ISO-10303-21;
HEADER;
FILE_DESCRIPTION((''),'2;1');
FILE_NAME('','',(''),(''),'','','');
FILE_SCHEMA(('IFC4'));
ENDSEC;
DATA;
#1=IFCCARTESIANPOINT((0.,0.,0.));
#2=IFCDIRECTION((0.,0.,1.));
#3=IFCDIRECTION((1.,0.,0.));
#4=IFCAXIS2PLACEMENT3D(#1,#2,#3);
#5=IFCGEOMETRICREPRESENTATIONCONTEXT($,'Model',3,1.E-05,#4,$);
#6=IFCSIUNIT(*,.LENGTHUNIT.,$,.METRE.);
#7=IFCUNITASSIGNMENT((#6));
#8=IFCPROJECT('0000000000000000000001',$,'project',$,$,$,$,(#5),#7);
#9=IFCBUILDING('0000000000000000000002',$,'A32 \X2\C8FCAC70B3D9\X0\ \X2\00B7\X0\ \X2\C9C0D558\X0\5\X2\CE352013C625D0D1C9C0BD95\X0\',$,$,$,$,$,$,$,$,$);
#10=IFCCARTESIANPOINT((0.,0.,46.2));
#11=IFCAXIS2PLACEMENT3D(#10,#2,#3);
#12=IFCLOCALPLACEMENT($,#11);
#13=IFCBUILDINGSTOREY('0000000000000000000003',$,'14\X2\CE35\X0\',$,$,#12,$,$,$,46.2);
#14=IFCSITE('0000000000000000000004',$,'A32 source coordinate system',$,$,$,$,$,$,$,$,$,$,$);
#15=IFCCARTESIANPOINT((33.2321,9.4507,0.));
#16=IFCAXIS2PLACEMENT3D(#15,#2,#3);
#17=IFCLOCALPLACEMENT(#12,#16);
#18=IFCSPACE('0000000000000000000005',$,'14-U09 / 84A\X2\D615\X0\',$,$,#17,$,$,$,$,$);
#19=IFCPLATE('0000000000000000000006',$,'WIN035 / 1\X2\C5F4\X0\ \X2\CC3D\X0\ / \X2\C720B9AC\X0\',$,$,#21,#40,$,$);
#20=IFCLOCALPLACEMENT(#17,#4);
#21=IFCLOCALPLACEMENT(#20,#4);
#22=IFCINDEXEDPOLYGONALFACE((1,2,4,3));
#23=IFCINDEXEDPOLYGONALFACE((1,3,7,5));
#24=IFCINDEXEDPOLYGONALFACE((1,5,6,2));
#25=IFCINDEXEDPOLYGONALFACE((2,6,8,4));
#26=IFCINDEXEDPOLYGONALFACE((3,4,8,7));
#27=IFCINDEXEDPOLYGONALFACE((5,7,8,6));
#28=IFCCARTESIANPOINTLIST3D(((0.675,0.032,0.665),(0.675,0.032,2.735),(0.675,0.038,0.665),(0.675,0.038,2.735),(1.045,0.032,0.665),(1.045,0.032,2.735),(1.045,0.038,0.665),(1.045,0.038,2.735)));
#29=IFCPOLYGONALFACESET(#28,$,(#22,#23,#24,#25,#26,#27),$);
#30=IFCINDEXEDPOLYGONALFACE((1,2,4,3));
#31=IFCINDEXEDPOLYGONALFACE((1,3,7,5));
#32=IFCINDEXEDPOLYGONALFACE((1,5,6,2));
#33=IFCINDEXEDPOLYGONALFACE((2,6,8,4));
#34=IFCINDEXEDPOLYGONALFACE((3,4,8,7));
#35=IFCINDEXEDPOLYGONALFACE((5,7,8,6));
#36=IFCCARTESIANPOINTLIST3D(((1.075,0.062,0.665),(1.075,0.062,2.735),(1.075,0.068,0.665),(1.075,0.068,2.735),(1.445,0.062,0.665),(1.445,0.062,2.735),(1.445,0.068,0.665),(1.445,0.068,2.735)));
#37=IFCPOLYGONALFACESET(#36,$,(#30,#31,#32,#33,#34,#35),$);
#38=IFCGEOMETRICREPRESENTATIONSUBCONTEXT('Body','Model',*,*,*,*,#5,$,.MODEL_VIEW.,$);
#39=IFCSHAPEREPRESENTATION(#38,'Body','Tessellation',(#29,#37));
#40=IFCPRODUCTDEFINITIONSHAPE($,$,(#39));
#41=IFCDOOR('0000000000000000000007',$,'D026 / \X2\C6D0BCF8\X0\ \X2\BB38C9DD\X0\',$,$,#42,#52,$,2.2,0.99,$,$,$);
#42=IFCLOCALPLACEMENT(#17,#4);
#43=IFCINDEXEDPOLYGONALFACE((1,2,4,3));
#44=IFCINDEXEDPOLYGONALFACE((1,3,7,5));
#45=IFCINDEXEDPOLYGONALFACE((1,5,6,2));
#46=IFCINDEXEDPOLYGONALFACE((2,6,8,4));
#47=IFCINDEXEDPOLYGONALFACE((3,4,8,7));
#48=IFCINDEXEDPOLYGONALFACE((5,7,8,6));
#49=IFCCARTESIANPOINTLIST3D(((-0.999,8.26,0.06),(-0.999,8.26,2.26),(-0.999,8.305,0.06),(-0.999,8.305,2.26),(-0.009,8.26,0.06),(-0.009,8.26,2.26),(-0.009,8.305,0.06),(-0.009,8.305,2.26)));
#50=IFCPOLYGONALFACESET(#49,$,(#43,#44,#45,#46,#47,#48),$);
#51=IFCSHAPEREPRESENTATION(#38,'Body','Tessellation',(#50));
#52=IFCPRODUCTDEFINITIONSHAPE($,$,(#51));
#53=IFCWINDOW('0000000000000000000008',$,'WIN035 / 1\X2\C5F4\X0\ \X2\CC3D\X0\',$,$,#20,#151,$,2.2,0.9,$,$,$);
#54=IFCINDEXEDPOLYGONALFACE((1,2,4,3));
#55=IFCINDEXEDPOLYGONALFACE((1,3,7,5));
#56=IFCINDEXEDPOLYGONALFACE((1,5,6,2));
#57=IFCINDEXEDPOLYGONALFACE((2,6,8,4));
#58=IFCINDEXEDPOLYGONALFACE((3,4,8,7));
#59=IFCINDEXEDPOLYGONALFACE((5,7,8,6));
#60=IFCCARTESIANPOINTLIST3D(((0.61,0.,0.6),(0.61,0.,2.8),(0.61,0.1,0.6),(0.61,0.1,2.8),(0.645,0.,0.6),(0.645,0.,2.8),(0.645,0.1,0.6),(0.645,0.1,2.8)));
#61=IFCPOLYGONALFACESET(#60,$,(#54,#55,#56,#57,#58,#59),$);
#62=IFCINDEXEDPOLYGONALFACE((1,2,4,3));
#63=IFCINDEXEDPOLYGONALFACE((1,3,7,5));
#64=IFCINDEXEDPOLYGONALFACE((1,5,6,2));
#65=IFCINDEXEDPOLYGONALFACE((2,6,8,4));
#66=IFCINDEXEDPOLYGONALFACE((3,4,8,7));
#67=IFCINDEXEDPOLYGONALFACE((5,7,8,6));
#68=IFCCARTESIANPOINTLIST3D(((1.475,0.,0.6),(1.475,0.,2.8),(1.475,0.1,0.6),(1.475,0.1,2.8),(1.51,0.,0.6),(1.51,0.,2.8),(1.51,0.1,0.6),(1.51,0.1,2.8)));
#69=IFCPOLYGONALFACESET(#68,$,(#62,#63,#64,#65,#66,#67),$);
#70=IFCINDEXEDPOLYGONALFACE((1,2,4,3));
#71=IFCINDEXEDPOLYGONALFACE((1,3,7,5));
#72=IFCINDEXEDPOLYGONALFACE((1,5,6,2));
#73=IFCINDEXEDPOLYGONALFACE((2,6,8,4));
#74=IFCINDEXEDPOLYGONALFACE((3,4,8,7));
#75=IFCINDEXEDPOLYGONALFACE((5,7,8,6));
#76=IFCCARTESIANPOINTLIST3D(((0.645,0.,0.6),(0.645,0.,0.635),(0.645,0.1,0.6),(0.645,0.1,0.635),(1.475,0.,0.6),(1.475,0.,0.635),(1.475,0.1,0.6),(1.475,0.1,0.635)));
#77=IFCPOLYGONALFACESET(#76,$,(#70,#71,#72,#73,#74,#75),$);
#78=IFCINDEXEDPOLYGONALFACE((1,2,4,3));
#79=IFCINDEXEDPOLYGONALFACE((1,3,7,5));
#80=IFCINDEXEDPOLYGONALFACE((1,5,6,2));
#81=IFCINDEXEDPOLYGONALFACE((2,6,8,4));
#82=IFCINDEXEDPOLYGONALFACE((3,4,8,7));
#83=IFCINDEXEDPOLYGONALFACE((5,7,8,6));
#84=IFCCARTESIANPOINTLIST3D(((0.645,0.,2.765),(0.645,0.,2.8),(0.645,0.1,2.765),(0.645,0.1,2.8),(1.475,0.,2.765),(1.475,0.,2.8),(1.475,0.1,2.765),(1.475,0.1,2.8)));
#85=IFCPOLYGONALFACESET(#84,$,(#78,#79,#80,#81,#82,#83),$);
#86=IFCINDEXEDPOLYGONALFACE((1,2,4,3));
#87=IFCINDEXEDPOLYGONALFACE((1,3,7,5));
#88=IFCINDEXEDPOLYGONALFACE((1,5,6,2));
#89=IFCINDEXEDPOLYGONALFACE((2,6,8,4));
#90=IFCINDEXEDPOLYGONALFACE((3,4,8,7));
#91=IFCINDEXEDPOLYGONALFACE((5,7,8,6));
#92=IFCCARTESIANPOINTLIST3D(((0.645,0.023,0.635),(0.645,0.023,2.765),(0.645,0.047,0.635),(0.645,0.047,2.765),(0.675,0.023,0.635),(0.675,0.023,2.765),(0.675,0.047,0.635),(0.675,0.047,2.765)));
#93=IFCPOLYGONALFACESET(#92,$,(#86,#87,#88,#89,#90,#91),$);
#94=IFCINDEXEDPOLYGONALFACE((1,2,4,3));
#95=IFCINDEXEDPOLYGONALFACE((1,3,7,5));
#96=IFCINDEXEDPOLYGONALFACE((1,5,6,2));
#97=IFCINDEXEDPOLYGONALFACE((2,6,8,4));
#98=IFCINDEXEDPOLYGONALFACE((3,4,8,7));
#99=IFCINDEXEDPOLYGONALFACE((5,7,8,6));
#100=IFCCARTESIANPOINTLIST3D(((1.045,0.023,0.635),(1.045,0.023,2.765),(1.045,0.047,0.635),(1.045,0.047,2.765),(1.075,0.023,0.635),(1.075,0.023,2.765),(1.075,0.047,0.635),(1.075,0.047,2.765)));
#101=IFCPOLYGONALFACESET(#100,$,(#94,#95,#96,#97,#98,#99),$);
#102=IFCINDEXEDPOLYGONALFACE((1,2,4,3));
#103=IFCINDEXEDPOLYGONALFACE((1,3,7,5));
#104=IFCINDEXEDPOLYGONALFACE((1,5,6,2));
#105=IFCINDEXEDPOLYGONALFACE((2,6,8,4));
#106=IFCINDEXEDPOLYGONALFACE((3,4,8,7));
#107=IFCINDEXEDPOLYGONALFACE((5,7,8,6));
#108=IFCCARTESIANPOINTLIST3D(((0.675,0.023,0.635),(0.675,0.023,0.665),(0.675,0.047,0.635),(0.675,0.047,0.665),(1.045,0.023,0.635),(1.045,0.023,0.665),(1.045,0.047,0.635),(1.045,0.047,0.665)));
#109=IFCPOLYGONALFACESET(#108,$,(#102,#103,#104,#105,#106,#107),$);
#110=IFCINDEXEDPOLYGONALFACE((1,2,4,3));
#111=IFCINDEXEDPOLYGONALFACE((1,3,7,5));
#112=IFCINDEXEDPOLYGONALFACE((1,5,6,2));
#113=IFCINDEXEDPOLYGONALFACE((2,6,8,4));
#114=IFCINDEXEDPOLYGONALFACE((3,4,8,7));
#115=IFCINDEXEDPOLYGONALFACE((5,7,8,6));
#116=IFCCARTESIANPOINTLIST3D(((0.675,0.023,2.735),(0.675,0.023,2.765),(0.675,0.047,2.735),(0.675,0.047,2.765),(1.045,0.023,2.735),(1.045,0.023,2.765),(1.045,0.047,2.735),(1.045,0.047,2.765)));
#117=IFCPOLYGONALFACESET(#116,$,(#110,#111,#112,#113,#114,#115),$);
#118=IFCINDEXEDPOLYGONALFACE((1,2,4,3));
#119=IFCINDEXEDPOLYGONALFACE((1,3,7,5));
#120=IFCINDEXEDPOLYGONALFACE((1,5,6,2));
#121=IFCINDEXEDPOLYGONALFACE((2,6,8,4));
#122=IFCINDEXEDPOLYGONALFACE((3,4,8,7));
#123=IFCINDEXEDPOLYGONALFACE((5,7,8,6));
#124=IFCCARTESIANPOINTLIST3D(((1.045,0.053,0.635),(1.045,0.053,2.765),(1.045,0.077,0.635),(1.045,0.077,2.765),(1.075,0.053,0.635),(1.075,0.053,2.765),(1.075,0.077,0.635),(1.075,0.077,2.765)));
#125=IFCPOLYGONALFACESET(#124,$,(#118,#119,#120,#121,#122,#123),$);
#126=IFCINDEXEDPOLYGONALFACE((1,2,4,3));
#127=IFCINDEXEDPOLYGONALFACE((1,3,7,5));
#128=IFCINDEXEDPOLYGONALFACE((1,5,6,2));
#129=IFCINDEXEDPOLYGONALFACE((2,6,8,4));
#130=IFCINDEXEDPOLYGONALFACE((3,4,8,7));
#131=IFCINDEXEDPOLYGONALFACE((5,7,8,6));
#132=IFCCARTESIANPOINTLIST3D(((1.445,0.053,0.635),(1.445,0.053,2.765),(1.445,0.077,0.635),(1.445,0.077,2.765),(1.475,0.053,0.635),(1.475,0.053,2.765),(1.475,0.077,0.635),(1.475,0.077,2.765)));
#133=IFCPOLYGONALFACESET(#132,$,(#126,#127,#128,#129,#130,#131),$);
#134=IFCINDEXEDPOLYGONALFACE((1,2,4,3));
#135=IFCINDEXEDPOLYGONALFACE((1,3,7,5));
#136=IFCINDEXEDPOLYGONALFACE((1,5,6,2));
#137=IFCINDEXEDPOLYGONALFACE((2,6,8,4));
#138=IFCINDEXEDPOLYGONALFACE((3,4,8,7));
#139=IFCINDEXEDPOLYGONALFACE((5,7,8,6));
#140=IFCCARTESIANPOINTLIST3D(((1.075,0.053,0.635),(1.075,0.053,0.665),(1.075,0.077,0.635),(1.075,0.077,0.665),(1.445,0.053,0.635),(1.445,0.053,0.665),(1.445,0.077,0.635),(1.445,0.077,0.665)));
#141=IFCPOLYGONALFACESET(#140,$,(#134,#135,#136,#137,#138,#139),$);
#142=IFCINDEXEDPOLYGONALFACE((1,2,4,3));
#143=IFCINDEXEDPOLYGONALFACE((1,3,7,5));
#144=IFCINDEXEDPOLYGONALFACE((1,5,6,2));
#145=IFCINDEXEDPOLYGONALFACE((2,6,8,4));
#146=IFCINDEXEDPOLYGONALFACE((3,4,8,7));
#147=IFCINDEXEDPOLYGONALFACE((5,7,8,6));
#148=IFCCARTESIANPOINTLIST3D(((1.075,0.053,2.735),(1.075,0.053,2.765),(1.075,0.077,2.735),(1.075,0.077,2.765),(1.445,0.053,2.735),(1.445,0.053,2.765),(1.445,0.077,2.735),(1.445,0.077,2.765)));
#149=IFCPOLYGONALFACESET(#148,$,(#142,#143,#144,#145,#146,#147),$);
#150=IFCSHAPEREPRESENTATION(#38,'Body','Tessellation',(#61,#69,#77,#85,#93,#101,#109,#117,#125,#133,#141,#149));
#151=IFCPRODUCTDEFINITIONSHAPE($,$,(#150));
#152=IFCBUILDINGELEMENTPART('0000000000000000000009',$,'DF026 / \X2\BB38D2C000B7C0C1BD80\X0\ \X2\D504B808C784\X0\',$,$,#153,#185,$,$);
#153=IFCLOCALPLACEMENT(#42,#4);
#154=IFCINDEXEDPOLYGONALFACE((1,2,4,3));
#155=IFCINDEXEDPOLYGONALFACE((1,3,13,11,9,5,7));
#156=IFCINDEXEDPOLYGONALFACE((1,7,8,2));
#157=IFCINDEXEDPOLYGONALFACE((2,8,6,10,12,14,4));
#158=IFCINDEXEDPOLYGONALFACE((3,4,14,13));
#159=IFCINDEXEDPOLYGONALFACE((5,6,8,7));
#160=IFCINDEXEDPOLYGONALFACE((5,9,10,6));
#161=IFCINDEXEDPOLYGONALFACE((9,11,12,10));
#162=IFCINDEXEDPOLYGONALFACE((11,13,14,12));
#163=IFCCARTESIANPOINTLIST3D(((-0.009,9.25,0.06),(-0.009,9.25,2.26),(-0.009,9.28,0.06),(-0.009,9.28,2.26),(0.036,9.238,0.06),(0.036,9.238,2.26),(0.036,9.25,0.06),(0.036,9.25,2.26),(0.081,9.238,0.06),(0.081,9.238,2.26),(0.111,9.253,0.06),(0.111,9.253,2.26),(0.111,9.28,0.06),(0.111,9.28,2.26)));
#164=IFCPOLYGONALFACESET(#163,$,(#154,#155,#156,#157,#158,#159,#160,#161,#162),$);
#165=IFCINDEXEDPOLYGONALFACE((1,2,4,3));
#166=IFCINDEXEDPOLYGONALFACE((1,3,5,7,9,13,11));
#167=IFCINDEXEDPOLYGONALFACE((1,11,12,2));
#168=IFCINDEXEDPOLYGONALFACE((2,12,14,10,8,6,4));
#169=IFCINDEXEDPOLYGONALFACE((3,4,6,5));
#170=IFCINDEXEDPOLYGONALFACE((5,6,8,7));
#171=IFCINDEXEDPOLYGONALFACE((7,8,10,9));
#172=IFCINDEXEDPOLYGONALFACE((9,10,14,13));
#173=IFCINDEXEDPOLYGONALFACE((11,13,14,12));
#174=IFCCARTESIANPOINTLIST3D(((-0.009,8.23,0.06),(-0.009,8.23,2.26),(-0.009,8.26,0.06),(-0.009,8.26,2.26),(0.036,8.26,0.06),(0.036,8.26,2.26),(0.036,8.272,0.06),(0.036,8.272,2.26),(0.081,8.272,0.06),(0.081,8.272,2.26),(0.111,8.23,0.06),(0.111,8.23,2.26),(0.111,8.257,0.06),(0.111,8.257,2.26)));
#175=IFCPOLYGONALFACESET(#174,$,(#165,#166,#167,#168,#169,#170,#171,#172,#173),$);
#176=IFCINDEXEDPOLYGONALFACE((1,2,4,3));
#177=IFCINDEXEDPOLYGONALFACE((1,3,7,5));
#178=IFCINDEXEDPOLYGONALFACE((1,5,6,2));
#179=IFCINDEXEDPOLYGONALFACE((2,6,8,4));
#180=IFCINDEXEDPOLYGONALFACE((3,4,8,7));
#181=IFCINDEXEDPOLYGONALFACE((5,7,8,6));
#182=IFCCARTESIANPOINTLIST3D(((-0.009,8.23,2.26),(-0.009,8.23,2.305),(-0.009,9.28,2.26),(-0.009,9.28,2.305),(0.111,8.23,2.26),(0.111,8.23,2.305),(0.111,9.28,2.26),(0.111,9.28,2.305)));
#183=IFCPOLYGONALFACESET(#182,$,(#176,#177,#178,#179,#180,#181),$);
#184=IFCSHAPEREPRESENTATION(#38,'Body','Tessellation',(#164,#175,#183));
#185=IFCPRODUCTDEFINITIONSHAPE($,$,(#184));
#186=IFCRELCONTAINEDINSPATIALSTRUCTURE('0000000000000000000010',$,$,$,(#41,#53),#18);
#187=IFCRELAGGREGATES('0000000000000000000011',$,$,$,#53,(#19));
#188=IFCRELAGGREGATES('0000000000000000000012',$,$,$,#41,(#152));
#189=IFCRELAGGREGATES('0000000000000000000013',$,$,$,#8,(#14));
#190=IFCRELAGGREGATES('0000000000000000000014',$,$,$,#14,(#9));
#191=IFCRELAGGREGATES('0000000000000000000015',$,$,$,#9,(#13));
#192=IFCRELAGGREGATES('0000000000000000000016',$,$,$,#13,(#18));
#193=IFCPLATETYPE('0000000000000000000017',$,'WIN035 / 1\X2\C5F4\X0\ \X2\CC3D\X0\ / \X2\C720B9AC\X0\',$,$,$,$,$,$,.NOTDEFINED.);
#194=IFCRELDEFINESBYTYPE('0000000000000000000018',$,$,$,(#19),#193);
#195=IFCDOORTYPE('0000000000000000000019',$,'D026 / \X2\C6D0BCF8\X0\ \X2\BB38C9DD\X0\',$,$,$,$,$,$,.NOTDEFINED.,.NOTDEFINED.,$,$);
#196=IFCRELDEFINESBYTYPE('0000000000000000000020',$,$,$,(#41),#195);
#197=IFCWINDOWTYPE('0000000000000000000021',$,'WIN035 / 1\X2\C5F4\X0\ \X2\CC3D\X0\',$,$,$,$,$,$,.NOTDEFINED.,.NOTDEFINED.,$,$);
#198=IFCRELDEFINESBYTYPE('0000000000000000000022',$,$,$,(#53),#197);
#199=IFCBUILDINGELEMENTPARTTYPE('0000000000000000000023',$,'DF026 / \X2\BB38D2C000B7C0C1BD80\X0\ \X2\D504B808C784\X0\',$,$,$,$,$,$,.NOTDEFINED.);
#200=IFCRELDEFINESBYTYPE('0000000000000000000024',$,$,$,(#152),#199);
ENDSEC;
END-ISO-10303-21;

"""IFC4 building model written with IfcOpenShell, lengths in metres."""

from ifc_helpers import new_model, si_unit, frame, origin, origin_with_axes, place, context, subcontext, project, spatial, polyline, outline, extrude, source, transform, mapped, type_object, type_shapes, element, aggregate, save


model = new_model("IFC4")

# Units and contexts
model_context = context("Model", 3, precision=1e-05, world=origin_with_axes())
body_context = subcontext(model_context, "Body", "Model", "MODEL_VIEW")
ifc_project = project(units=[si_unit("LENGTHUNIT", "METRE")], contexts=[model_context])

# Plate
plate_type_1 = type_object("IfcPlateType", Name="WIN035 / 1열 창 / 유리", PredefinedType="NOTDEFINED")
shared_shape_1 = source(origin(), body_context, "Body", "SweptSolid", [
    extrude(outline(polyline([(0.675, 0.032), (0.675, 0.038), (1.045, 0.038), (1.045, 0.032), (0.675, 0.032)])), frame((0.0, 0.0, 0.665)), (0.0, 0.0, 1.0), 2.07),
    extrude(outline(polyline([(1.075, 0.062), (1.075, 0.068), (1.445, 0.068), (1.445, 0.062), (1.075, 0.062)])), frame((0.0, 0.0, 0.665)), (0.0, 0.0, 1.0), 2.07),
])
type_shapes(plate_type_1, [shared_shape_1])
storey_placement = place(None, frame((0.0, 0.0, 46.2), z_axis=(0.0, 0.0, 1.0), x_axis=(1.0, 0.0, 0.0)))
space_placement = place(storey_placement, frame((33.2321, 9.4507, 0.0), z_axis=(0.0, 0.0, 1.0), x_axis=(1.0, 0.0, 0.0)))
window_1_placement = place(space_placement, origin_with_axes())
plate_1_placement = place(window_1_placement, origin_with_axes())
plate_1 = element("IfcPlate", 1, at=plate_1_placement, type_object=plate_type_1, Name="WIN035 / 1열 창 / 유리", context=body_context, shape_type="MappedRepresentation", body=[
    mapped(shared_shape_1, transform((0.0, 0.0, 0.0), scale=1.0)),
])

# Site, building, storey, space
site = spatial("IfcSite", under=ifc_project, Name="A32 source coordinate system")
building = spatial("IfcBuilding", under=site, Name="A32 주거동 · 지하5층–옥탑지붕")
storey = spatial("IfcBuildingStorey", under=building, at=storey_placement, Name="14층", Elevation=46.2)
space = spatial("IfcSpace", under=storey, at=space_placement, Name="14-U09 / 84A형")

# Door
door_type_1 = type_object("IfcDoorType", Name="D026 / 원본 문짝", OperationType="NOTDEFINED", PredefinedType="NOTDEFINED")
shared_shape_2 = source(origin(), body_context, "Body", "SweptSolid", [
    extrude(outline(polyline([(-0.009, 8.26), (-0.999, 8.26), (-0.999, 8.305), (-0.009, 8.305), (-0.009, 8.26)])), frame((0.0, 0.0, 0.06)), (0.0, 0.0, 1.0), 2.2),
])
type_shapes(door_type_1, [shared_shape_2])
door_1_placement = place(space_placement, origin_with_axes())
door_1 = element("IfcDoor", 2, at=door_1_placement, inside=space, type_object=door_type_1, Name="D026 / 원본 문짝", OverallHeight=2.2, OverallWidth=0.99, context=body_context, shape_type="MappedRepresentation", body=[
    mapped(shared_shape_2, transform((0.0, 0.0, 0.0), scale=1.0)),
])

# Window
window_type_1 = type_object("IfcWindowType", Name="WIN035 / 1열 창", PartitioningType="NOTDEFINED", PredefinedType="NOTDEFINED")
shared_shape_3 = source(origin(), body_context, "Body", "SweptSolid", [
    extrude(outline(polyline([(0.61, 0.0), (0.61, 0.1), (0.645, 0.1), (0.645, 0.0), (0.61, 0.0)])), frame((0.0, 0.0, 0.6)), (0.0, 0.0, 1.0), 2.2),
    extrude(outline(polyline([(1.475, 0.0), (1.475, 0.1), (1.51, 0.1), (1.51, 0.0), (1.475, 0.0)])), frame((0.0, 0.0, 0.6)), (0.0, 0.0, 1.0), 2.2),
    extrude(outline(polyline([(0.645, 0.0), (0.645, 0.1), (1.475, 0.1), (1.475, 0.0), (0.645, 0.0)])), frame((0.0, 0.0, 0.6)), (0.0, 0.0, 1.0), 0.035),
    extrude(outline(polyline([(0.645, 0.0), (0.645, 0.1), (1.475, 0.1), (1.475, 0.0), (0.645, 0.0)])), frame((0.0, 0.0, 2.765)), (0.0, 0.0, 1.0), 0.035),
    extrude(outline(polyline([(0.645, 0.023), (0.645, 0.047), (0.675, 0.047), (0.675, 0.023), (0.645, 0.023)])), frame((0.0, 0.0, 0.635)), (0.0, 0.0, 1.0), 2.13),
    extrude(outline(polyline([(1.045, 0.023), (1.045, 0.047), (1.075, 0.047), (1.075, 0.023), (1.045, 0.023)])), frame((0.0, 0.0, 0.635)), (0.0, 0.0, 1.0), 2.13),
    extrude(outline(polyline([(0.675, 0.023), (0.675, 0.047), (1.045, 0.047), (1.045, 0.023), (0.675, 0.023)])), frame((0.0, 0.0, 0.635)), (0.0, 0.0, 1.0), 0.03),
    extrude(outline(polyline([(0.675, 0.023), (0.675, 0.047), (1.045, 0.047), (1.045, 0.023), (0.675, 0.023)])), frame((0.0, 0.0, 2.735)), (0.0, 0.0, 1.0), 0.03),
    extrude(outline(polyline([(1.045, 0.053), (1.045, 0.077), (1.075, 0.077), (1.075, 0.053), (1.045, 0.053)])), frame((0.0, 0.0, 0.635)), (0.0, 0.0, 1.0), 2.13),
    extrude(outline(polyline([(1.445, 0.053), (1.445, 0.077), (1.475, 0.077), (1.475, 0.053), (1.445, 0.053)])), frame((0.0, 0.0, 0.635)), (0.0, 0.0, 1.0), 2.13),
    extrude(outline(polyline([(1.075, 0.053), (1.075, 0.077), (1.445, 0.077), (1.445, 0.053), (1.075, 0.053)])), frame((0.0, 0.0, 0.635)), (0.0, 0.0, 1.0), 0.03),
    extrude(outline(polyline([(1.075, 0.053), (1.075, 0.077), (1.445, 0.077), (1.445, 0.053), (1.075, 0.053)])), frame((0.0, 0.0, 2.735)), (0.0, 0.0, 1.0), 0.03),
])
type_shapes(window_type_1, [shared_shape_3])
window_1 = element("IfcWindow", 3, at=window_1_placement, inside=space, type_object=window_type_1, Name="WIN035 / 1열 창", OverallHeight=2.2, OverallWidth=0.9, context=body_context, shape_type="MappedRepresentation", body=[
    mapped(shared_shape_3, transform((0.0, 0.0, 0.0), scale=1.0)),
])
aggregate(window_1, [plate_1])

# Building element part
building_element_part_type_1 = type_object("IfcBuildingElementPartType", Name="DF026 / 문틀·상부 프레임", PredefinedType="NOTDEFINED")
shared_shape_4 = source(origin(), body_context, "Body", "SweptSolid", [
    extrude(outline(polyline([(0.111, 9.28), (0.111, 9.253), (0.081, 9.238), (0.036, 9.238), (0.036, 9.25), (-0.009, 9.25), (-0.009, 9.28), (0.111, 9.28)])), frame((0.0, 0.0, 0.06)), (0.0, 0.0, 1.0), 2.2),
    extrude(outline(polyline([(-0.009, 8.26), (0.036, 8.26), (0.036, 8.272), (0.081, 8.272), (0.111, 8.257), (0.111, 8.23), (-0.009, 8.23), (-0.009, 8.26)])), frame((0.0, 0.0, 0.06)), (0.0, 0.0, 1.0), 2.2),
    extrude(outline(polyline([(-0.009, 8.23), (-0.009, 9.28), (0.111, 9.28), (0.111, 8.23), (-0.009, 8.23)])), frame((0.0, 0.0, 2.26)), (0.0, 0.0, 1.0), 0.045),
])
type_shapes(building_element_part_type_1, [shared_shape_4])
building_element_part_1_placement = place(door_1_placement, origin_with_axes())
building_element_part_1 = element("IfcBuildingElementPart", 4, at=building_element_part_1_placement, type_object=building_element_part_type_1, Name="DF026 / 문틀·상부 프레임", context=body_context, shape_type="MappedRepresentation", body=[
    mapped(shared_shape_4, transform((0.0, 0.0, 0.0), scale=1.0)),
])
aggregate(door_1, [building_element_part_1])

save(model, "model.ifc")
